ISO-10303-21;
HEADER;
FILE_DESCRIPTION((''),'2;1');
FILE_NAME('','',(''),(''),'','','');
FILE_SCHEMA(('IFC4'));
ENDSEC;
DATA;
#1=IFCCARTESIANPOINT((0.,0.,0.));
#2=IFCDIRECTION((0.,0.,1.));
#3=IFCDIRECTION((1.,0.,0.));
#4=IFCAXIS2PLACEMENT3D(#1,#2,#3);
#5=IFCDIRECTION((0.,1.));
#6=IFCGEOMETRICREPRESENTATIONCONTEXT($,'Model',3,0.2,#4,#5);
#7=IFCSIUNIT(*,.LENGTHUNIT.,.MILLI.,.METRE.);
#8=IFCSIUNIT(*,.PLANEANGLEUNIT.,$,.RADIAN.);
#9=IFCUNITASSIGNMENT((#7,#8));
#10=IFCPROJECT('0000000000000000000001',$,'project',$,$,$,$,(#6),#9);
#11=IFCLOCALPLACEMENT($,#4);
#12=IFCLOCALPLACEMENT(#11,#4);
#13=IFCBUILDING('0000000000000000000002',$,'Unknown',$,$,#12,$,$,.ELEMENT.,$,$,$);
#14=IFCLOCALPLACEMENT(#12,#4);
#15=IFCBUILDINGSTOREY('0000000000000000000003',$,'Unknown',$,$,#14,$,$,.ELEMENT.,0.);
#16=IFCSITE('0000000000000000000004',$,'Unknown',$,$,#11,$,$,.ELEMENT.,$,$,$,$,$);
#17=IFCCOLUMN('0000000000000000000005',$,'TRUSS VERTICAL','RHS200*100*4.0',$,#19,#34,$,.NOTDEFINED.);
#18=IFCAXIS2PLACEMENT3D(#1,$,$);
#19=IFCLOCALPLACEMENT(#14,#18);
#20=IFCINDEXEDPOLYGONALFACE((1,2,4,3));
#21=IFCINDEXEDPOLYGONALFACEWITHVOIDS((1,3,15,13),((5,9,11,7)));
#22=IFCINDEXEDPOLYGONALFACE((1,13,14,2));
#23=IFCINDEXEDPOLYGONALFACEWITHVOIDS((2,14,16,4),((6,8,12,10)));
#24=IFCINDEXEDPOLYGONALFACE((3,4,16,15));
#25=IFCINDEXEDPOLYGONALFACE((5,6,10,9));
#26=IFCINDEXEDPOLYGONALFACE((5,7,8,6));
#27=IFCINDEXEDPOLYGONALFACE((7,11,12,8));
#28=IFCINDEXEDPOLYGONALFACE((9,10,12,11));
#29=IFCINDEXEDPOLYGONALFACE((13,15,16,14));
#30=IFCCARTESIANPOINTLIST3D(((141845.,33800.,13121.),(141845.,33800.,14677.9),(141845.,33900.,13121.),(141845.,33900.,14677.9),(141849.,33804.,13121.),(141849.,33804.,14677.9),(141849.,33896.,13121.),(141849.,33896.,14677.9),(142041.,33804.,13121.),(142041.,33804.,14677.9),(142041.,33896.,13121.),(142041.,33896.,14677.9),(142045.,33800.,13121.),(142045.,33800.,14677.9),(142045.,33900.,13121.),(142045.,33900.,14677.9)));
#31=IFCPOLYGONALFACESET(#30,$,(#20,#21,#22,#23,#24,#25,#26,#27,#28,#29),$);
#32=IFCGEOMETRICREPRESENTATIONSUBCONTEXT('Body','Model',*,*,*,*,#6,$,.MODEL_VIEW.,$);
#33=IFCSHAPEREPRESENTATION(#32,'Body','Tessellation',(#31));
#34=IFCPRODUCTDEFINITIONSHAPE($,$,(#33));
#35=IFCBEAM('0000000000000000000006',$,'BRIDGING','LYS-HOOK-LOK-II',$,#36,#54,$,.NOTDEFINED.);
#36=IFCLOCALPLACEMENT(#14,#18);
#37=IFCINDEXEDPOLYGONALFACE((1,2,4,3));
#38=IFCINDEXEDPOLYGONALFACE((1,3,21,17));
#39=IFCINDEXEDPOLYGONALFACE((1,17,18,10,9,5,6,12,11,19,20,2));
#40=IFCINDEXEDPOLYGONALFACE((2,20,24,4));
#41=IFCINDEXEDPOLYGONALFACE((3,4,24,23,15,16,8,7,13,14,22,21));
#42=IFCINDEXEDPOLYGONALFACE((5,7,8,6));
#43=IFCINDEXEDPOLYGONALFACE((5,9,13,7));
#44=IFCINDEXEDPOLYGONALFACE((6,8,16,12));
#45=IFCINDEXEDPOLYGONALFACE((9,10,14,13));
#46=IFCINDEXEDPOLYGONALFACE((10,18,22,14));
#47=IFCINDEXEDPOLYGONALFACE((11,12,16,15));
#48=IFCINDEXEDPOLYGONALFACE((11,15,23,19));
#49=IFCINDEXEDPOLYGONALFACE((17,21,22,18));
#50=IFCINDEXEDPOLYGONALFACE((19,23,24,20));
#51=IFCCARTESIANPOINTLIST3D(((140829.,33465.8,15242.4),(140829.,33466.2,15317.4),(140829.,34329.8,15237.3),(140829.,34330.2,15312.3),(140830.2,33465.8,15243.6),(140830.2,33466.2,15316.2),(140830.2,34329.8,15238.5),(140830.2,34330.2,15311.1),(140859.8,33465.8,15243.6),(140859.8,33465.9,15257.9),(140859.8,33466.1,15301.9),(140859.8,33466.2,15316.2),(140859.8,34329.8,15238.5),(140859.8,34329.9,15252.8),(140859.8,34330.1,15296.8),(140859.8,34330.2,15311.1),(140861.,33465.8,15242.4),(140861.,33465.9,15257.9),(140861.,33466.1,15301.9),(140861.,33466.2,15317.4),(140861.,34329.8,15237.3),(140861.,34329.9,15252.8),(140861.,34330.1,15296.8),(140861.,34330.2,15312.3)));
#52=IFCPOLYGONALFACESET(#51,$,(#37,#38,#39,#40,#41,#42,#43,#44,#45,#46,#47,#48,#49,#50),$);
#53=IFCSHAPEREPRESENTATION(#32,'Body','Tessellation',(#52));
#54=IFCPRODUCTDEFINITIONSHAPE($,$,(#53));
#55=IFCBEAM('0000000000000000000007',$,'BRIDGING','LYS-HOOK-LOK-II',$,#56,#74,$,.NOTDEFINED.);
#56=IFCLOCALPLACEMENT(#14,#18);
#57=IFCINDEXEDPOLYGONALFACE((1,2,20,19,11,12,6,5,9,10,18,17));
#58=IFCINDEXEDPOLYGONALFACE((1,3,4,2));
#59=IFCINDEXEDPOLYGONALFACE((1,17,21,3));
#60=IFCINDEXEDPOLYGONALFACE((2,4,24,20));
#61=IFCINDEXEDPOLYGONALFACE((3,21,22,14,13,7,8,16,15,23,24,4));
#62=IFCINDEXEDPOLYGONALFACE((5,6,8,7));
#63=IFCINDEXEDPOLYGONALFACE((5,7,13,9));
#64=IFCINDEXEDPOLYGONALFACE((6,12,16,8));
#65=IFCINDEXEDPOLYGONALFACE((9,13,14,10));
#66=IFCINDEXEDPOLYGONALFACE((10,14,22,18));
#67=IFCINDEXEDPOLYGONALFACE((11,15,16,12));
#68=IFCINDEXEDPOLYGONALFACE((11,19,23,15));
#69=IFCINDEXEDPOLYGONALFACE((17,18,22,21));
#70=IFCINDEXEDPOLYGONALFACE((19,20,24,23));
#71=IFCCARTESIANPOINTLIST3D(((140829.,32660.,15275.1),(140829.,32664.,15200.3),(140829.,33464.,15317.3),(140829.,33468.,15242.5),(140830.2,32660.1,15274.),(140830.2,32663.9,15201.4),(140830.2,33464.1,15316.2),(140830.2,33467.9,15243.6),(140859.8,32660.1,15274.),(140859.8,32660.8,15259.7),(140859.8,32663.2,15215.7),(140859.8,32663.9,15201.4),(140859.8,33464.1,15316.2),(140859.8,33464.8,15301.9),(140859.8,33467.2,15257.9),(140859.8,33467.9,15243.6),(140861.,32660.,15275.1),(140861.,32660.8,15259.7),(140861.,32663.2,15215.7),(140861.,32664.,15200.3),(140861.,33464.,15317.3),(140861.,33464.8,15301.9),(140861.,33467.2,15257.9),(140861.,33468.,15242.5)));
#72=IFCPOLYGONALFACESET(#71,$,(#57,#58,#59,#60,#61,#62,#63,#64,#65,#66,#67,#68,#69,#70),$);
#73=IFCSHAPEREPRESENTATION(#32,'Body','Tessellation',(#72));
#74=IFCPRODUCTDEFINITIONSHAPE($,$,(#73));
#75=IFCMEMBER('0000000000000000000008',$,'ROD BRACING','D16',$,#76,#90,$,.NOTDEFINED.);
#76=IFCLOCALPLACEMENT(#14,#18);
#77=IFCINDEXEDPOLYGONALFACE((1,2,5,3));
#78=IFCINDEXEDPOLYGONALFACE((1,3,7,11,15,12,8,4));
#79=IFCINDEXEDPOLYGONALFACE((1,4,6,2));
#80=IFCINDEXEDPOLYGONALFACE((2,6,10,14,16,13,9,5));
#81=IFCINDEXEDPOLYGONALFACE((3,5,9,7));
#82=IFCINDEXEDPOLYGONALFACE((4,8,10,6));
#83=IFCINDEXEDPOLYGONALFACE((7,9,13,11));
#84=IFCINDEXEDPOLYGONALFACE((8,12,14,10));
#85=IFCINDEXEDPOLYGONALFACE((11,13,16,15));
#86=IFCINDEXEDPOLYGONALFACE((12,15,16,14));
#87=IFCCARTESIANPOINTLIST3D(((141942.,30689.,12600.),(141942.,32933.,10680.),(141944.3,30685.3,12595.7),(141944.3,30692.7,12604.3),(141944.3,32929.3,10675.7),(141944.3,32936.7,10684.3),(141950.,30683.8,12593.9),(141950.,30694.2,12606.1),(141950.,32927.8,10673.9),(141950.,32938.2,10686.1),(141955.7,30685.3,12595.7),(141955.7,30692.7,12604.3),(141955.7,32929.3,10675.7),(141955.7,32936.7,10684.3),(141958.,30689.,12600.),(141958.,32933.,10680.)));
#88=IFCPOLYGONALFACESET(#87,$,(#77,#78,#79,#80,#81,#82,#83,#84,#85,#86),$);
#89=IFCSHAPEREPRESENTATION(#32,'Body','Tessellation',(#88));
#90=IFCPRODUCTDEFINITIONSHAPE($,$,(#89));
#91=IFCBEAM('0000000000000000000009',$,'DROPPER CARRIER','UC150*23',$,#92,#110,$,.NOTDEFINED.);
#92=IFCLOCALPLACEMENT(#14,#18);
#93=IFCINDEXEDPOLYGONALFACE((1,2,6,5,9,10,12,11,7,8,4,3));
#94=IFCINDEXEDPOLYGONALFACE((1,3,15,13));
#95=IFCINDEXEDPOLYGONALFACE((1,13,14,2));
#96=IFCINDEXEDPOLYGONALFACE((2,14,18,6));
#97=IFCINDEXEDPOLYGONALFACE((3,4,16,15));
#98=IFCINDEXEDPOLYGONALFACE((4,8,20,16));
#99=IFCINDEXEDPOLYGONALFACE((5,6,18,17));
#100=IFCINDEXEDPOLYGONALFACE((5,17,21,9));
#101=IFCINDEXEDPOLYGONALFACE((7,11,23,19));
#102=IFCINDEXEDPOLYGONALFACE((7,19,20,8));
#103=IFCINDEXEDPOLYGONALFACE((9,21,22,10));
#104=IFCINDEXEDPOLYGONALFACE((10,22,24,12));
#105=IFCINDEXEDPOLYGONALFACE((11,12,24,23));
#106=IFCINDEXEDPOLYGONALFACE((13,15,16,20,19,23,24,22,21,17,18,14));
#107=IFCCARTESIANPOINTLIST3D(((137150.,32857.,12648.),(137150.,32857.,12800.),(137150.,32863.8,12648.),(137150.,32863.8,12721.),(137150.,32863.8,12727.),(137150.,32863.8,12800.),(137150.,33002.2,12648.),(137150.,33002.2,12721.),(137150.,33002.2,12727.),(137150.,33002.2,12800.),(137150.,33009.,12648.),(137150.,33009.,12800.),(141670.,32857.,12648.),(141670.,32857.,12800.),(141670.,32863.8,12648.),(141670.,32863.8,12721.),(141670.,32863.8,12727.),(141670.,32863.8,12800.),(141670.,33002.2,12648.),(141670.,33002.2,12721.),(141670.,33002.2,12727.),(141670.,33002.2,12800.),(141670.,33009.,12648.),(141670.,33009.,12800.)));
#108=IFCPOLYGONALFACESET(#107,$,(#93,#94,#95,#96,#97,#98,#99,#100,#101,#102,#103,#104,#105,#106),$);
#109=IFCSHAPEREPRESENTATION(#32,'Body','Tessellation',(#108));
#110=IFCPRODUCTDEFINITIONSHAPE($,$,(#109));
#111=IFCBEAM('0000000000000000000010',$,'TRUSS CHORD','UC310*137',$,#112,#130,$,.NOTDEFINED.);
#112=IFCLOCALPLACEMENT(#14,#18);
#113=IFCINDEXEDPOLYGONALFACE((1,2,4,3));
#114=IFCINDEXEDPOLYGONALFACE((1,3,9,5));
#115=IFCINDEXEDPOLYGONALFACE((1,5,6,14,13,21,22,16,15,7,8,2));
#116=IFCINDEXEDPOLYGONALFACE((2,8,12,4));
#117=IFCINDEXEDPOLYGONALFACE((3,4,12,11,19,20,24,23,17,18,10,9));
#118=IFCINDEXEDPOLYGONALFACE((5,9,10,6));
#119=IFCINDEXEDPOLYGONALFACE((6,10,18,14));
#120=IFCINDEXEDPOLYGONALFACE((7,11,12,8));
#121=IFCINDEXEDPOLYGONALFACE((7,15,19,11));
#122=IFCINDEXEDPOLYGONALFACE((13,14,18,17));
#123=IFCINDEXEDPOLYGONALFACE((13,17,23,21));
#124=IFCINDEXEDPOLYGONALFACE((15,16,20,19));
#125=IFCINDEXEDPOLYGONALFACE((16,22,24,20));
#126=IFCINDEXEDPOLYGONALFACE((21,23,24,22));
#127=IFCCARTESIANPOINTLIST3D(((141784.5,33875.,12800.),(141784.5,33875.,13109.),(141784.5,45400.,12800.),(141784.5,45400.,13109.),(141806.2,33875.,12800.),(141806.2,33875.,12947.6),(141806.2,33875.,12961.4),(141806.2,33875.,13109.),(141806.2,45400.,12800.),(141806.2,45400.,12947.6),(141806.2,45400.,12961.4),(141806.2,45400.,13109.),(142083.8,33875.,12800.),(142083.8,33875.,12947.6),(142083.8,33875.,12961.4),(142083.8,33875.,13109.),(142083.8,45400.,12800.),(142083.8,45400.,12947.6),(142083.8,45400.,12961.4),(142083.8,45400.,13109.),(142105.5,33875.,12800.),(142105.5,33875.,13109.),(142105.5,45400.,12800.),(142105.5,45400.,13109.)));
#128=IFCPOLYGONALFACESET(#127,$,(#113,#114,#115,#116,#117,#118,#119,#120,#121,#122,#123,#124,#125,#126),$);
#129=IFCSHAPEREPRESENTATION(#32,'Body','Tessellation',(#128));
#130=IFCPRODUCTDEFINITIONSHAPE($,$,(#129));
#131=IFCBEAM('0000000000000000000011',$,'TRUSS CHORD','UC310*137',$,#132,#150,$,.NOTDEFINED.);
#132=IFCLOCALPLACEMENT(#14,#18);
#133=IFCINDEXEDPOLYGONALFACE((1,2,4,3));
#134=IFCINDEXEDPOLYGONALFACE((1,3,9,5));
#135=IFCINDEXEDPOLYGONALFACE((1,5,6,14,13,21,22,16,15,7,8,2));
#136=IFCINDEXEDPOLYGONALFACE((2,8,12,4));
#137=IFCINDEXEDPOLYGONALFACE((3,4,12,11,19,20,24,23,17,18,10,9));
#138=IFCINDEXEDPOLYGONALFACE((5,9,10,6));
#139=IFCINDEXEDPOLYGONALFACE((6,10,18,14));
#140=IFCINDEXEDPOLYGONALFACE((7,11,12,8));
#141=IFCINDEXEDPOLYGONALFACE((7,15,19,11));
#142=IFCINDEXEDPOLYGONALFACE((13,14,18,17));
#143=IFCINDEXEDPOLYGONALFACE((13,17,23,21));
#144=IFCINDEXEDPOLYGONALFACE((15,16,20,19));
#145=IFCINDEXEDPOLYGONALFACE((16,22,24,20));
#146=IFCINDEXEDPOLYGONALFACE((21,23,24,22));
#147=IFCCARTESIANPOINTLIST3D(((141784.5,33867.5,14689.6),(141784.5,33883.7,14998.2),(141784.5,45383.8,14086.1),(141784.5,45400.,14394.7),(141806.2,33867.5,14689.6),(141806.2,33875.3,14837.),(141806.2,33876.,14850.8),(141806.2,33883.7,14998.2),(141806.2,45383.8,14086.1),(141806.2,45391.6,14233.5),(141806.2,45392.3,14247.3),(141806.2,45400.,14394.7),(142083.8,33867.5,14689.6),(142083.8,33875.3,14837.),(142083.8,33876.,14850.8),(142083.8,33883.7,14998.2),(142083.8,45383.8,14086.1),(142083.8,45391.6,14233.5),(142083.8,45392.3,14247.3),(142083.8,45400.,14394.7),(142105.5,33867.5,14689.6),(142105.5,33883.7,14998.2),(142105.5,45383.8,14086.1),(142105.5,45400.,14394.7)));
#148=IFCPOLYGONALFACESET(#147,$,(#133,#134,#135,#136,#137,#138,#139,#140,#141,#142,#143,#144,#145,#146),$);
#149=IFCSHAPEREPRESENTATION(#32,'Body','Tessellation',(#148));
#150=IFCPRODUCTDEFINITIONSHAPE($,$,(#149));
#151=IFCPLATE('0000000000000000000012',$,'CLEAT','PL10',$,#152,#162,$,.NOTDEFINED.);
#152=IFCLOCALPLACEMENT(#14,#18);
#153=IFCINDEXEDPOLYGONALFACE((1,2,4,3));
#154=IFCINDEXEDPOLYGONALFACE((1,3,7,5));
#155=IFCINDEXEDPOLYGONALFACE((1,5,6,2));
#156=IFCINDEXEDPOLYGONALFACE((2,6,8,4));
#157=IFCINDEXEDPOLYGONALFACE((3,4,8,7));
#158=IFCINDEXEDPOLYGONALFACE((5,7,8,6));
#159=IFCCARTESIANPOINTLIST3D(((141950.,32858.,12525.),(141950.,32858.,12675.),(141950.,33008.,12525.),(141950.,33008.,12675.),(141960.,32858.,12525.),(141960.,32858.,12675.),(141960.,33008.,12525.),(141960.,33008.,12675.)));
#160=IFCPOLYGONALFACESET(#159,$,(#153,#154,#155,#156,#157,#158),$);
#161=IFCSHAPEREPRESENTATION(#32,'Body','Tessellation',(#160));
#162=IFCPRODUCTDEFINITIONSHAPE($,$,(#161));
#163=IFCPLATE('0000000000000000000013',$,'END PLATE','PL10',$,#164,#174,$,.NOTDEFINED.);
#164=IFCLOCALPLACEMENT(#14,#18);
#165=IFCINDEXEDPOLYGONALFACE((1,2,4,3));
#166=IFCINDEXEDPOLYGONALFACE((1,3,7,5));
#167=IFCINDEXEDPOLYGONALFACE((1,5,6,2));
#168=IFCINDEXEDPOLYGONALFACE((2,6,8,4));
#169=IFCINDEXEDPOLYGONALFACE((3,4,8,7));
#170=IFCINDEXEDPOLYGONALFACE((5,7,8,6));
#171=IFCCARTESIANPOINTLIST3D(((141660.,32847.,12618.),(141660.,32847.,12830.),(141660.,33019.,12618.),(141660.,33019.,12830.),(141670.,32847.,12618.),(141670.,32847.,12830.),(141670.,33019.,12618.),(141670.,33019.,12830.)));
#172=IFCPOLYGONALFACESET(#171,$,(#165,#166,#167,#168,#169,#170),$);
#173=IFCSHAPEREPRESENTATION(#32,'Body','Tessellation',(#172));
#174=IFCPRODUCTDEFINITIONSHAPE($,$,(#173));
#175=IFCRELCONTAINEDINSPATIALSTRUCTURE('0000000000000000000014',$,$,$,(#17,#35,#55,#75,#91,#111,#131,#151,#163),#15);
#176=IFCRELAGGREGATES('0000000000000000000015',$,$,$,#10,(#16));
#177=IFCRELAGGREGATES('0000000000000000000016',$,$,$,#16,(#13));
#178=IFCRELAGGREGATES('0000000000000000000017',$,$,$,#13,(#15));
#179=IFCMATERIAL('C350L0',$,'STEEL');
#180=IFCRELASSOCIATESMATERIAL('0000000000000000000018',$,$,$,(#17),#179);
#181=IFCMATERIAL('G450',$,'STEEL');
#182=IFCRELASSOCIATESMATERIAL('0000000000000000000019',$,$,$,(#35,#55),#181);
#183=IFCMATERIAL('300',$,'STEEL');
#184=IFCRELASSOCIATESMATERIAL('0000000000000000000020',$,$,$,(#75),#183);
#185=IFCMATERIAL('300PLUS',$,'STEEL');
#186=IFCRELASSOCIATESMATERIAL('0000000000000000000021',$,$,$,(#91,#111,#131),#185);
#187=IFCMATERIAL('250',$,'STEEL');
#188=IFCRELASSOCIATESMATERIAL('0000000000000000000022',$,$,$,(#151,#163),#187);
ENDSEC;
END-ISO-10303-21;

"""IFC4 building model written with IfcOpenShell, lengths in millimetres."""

from ifc_helpers import new_model, si_unit, direction, frame, origin_with_axes, place, context, subcontext, project, spatial, line, indexed_curve, outline, extrude, material, element, save


model = new_model("IFC4")

# Units and contexts
model_context = context("Model", 3, precision=0.2, world=origin_with_axes(), true_north=direction((0.0, 1.0)))
body_context = subcontext(model_context, "Body", "Model", "MODEL_VIEW")
ifc_project = project(units=[si_unit("LENGTHUNIT", "METRE", prefix="MILLI"), si_unit("PLANEANGLEUNIT", "RADIAN")], contexts=[model_context])

# Site, building, storey
site_placement = place(None, origin_with_axes())
site = spatial("IfcSite", under=ifc_project, at=site_placement, Name="Unknown", CompositionType="ELEMENT")
building_placement = place(site_placement, origin_with_axes())
building = spatial("IfcBuilding", under=site, at=building_placement, Name="Unknown", CompositionType="ELEMENT")
storey_placement = place(building_placement, origin_with_axes())
storey = spatial("IfcBuildingStorey", under=building, at=storey_placement, Name="Unknown", CompositionType="ELEMENT", Elevation=0.0)

# Column
ifc_material_1 = material(Name="C350L0", Category="STEEL")
column_placement = place(storey_placement, frame((141945.0, 33850.0, 13121.0), z_axis=(0.0, -1.0, 0.0), x_axis=(0.0, 0.0, 1.0)))
element("IfcColumn", 1, at=column_placement, inside=storey, material=ifc_material_1, Name="TRUSS VERTICAL", Description="RHS200*100*4.0", PredefinedType="NOTDEFINED", context=body_context, shape_type="SolidModel", body=[
    extrude(outline(indexed_curve([(-50.0, -100.0), (50.0, -100.0), (50.0, 100.0), (-50.0, 100.0)], segments=[line(1, 2, 3, 4, 1)]), holes=[indexed_curve([(-46.0, -96.0), (-46.0, 96.0), (46.0, 96.0), (46.0, -96.0)], segments=[line(1, 2, 3, 4, 1)])]), frame((0.0, 0.0, 0.0), z_axis=(-1.0, 0.0, 0.0), x_axis=(0.0, 0.0, 1.0)), (0.0, 0.0, -1.0), 1556.9),
])

# Beams
ifc_material_2 = material(Name="G450", Category="STEEL")
beam_1_placement = place(storey_placement, frame((140845.0, 33466.0, 15279.9), z_axis=(1.0, 0.0, 0.0), x_axis=(0.0, 0.999983, -0.005903)))
element("IfcBeam", 2, at=beam_1_placement, inside=storey, material=ifc_material_2, Name="BRIDGING", Description="LYS-HOOK-LOK-II", PredefinedType="NOTDEFINED", context=body_context, shape_type="SolidModel", body=[
    extrude(outline(indexed_curve([(16.0, -37.5), (16.0, -22.0), (14.8, -22.0), (14.8, -36.3), (-14.8, -36.3), (-14.8, 36.3), (14.8, 36.3), (14.8, 22.0), (16.0, 22.0), (16.0, 37.5), (-16.0, 37.5), (-16.0, -37.5)], segments=[line(1, 2, 3, 4, 5, 6, 7, 8, 9, 10, 11, 12, 1)])), frame((0.0, 0.0, 0.0), z_axis=(-1.0, 0.0, 0.0), x_axis=(0.0, 0.0, 1.0)), (0.0, 0.0, -1.0), 864.0),
])
beam_2_placement = place(storey_placement, frame((140845.0, 32662.0, 15237.7), z_axis=(1.0, 0.0, 0.0), x_axis=(0.0, 0.998625, 0.052415)))
element("IfcBeam", 3, at=beam_2_placement, inside=storey, material=ifc_material_2, Name="BRIDGING", Description="LYS-HOOK-LOK-II", PredefinedType="NOTDEFINED", context=body_context, shape_type="SolidModel", body=[
    extrude(outline(indexed_curve([(16.0, -37.5), (16.0, -22.0), (14.8, -22.0), (14.8, -36.3), (-14.8, -36.3), (-14.8, 36.3), (14.8, 36.3), (14.8, 22.0), (16.0, 22.0), (16.0, 37.5), (-16.0, 37.5), (-16.0, -37.5)], segments=[line(1, 2, 3, 4, 5, 6, 7, 8, 9, 10, 11, 12, 1)])), frame((0.0, 0.0, 0.0), z_axis=(-1.0, 0.0, 0.0), x_axis=(0.0, 0.0, 1.0)), (0.0, 0.0, -1.0), 805.1),
])

# Member
ifc_material_3 = material(Name="300", Category="STEEL")
member_placement = place(storey_placement, frame((141950.0, 32933.0, 10680.0), z_axis=(0.0, 0.650122, 0.75983), x_axis=(0.0, -0.75983, 0.650122)))
element("IfcMember", 4, at=member_placement, inside=storey, material=ifc_material_3, Name="ROD BRACING", Description="D16", PredefinedType="NOTDEFINED", context=body_context, shape_type="SolidModel", body=[
    extrude(outline(indexed_curve([(8.0, 0.0), (5.7, 5.7), (0.0, 8.0), (-5.7, 5.7), (-8.0, 0.0), (-5.7, -5.7), (0.0, -8.0), (5.7, -5.7)], segments=[line(1, 2, 3, 4, 5, 6, 7, 8, 1)])), frame((0.0, 0.0, 0.0), z_axis=(-1.0, 0.0, 0.0), x_axis=(0.0, 0.0, 1.0)), (0.0, 0.0, -1.0), 2953.3),
])

# Beams
ifc_material_4 = material(Name="300PLUS", Category="STEEL")
beam_3_placement = place(storey_placement, frame((137150.0, 32933.0, 12724.0), z_axis=(0.0, 0.0, 1.0), x_axis=(1.0, 0.0, 0.0)))
element("IfcBeam", 5, at=beam_3_placement, inside=storey, material=ifc_material_4, Name="DROPPER CARRIER", Description="UC150*23", PredefinedType="NOTDEFINED", context=body_context, shape_type="SolidModel", body=[
    extrude(outline(indexed_curve([(-76.0, -76.0), (76.0, -76.0), (76.0, -69.2), (3.0, -69.2), (3.0, 69.2), (76.0, 69.2), (76.0, 76.0), (-76.0, 76.0), (-76.0, 69.2), (-3.0, 69.2), (-3.0, -69.2), (-76.0, -69.2)], segments=[line(1, 2, 3, 4, 5, 6, 7, 8, 9, 10, 11, 12, 1)])), frame((0.0, 0.0, 0.0), z_axis=(-1.0, 0.0, 0.0), x_axis=(0.0, 0.0, 1.0)), (0.0, 0.0, -1.0), 4520.0),
])
beam_4_placement = place(storey_placement, frame((141945.0, 33875.0, 12954.5), z_axis=(0.0, 0.0, 1.0), x_axis=(0.0, 1.0, 0.0)))
element("IfcBeam", 6, at=beam_4_placement, inside=storey, material=ifc_material_4, Name="TRUSS CHORD", Description="UC310*137", PredefinedType="NOTDEFINED", context=body_context, shape_type="SolidModel", body=[
    extrude(outline(indexed_curve([(-154.5, -160.5), (154.5, -160.5), (154.5, -138.8), (6.9, -138.8), (6.9, 138.8), (154.5, 138.8), (154.5, 160.5), (-154.5, 160.5), (-154.5, 138.8), (-6.9, 138.8), (-6.9, -138.8), (-154.5, -138.8)], segments=[line(1, 2, 3, 4, 5, 6, 7, 8, 9, 10, 11, 12, 1)])), frame((0.0, 0.0, 0.0), z_axis=(-1.0, 0.0, 0.0), x_axis=(0.0, 0.0, 1.0)), (0.0, 0.0, -1.0), 11525.0),
])
beam_5_placement = place(storey_placement, frame((141945.0, 33875.6, 14843.9), z_axis=(0.0, 0.052332, 0.99863), x_axis=(0.0, 0.99863, -0.052332)))
element("IfcBeam", 7, at=beam_5_placement, inside=storey, material=ifc_material_4, Name="TRUSS CHORD", Description="UC310*137", PredefinedType="NOTDEFINED", context=body_context, shape_type="SolidModel", body=[
    extrude(outline(indexed_curve([(-154.5, -160.5), (154.5, -160.5), (154.5, -138.8), (6.9, -138.8), (6.9, 138.8), (154.5, 138.8), (154.5, 160.5), (-154.5, 160.5), (-154.5, 138.8), (-6.9, 138.8), (-6.9, -138.8), (-154.5, -138.8)], segments=[line(1, 2, 3, 4, 5, 6, 7, 8, 9, 10, 11, 12, 1)])), frame((0.0, 0.0, 0.0), z_axis=(-1.0, 0.0, 0.0), x_axis=(0.0, 0.0, 1.0)), (0.0, 0.0, -1.0), 11532.1),
])

# Plates
ifc_material_5 = material(Name="250", Category="STEEL")
plate_1_placement = place(storey_placement, frame((141955.0, 32858.0, 12525.0), z_axis=(1.0, 0.0, 0.0), x_axis=(0.0, 1.0, 0.0)))
element("IfcPlate", 8, at=plate_1_placement, inside=storey, material=ifc_material_5, Name="CLEAT", Description="PL10", PredefinedType="NOTDEFINED", context=body_context, shape_type="SolidModel", body=[
    extrude(outline(indexed_curve([(0.0, 0.0), (150.0, 0.0), (150.0, 150.0), (0.0, 150.0)], segments=[line(1, 2, 3, 4, 1)])), frame((0.0, 0.0, 5.0), z_axis=(0.0, 0.0, 1.0), x_axis=(1.0, 0.0, 0.0)), (0.0, 0.0, -1.0), 10.0),
])
plate_2_placement = place(storey_placement, frame((141665.0, 33019.0, 12618.0), z_axis=(-1.0, 0.0, 0.0), x_axis=(0.0, -1.0, 0.0)))
element("IfcPlate", 9, at=plate_2_placement, inside=storey, material=ifc_material_5, Name="END PLATE", Description="PL10", PredefinedType="NOTDEFINED", context=body_context, shape_type="SolidModel", body=[
    extrude(outline(indexed_curve([(0.0, 0.0), (172.0, 0.0), (172.0, 212.0), (0.0, 212.0)], segments=[line(1, 2, 3, 4, 1)])), frame((0.0, 0.0, 5.0), z_axis=(0.0, 0.0, 1.0), x_axis=(1.0, 0.0, 0.0)), (0.0, 0.0, -1.0), 10.0),
])

save(model, "model.ifc")
